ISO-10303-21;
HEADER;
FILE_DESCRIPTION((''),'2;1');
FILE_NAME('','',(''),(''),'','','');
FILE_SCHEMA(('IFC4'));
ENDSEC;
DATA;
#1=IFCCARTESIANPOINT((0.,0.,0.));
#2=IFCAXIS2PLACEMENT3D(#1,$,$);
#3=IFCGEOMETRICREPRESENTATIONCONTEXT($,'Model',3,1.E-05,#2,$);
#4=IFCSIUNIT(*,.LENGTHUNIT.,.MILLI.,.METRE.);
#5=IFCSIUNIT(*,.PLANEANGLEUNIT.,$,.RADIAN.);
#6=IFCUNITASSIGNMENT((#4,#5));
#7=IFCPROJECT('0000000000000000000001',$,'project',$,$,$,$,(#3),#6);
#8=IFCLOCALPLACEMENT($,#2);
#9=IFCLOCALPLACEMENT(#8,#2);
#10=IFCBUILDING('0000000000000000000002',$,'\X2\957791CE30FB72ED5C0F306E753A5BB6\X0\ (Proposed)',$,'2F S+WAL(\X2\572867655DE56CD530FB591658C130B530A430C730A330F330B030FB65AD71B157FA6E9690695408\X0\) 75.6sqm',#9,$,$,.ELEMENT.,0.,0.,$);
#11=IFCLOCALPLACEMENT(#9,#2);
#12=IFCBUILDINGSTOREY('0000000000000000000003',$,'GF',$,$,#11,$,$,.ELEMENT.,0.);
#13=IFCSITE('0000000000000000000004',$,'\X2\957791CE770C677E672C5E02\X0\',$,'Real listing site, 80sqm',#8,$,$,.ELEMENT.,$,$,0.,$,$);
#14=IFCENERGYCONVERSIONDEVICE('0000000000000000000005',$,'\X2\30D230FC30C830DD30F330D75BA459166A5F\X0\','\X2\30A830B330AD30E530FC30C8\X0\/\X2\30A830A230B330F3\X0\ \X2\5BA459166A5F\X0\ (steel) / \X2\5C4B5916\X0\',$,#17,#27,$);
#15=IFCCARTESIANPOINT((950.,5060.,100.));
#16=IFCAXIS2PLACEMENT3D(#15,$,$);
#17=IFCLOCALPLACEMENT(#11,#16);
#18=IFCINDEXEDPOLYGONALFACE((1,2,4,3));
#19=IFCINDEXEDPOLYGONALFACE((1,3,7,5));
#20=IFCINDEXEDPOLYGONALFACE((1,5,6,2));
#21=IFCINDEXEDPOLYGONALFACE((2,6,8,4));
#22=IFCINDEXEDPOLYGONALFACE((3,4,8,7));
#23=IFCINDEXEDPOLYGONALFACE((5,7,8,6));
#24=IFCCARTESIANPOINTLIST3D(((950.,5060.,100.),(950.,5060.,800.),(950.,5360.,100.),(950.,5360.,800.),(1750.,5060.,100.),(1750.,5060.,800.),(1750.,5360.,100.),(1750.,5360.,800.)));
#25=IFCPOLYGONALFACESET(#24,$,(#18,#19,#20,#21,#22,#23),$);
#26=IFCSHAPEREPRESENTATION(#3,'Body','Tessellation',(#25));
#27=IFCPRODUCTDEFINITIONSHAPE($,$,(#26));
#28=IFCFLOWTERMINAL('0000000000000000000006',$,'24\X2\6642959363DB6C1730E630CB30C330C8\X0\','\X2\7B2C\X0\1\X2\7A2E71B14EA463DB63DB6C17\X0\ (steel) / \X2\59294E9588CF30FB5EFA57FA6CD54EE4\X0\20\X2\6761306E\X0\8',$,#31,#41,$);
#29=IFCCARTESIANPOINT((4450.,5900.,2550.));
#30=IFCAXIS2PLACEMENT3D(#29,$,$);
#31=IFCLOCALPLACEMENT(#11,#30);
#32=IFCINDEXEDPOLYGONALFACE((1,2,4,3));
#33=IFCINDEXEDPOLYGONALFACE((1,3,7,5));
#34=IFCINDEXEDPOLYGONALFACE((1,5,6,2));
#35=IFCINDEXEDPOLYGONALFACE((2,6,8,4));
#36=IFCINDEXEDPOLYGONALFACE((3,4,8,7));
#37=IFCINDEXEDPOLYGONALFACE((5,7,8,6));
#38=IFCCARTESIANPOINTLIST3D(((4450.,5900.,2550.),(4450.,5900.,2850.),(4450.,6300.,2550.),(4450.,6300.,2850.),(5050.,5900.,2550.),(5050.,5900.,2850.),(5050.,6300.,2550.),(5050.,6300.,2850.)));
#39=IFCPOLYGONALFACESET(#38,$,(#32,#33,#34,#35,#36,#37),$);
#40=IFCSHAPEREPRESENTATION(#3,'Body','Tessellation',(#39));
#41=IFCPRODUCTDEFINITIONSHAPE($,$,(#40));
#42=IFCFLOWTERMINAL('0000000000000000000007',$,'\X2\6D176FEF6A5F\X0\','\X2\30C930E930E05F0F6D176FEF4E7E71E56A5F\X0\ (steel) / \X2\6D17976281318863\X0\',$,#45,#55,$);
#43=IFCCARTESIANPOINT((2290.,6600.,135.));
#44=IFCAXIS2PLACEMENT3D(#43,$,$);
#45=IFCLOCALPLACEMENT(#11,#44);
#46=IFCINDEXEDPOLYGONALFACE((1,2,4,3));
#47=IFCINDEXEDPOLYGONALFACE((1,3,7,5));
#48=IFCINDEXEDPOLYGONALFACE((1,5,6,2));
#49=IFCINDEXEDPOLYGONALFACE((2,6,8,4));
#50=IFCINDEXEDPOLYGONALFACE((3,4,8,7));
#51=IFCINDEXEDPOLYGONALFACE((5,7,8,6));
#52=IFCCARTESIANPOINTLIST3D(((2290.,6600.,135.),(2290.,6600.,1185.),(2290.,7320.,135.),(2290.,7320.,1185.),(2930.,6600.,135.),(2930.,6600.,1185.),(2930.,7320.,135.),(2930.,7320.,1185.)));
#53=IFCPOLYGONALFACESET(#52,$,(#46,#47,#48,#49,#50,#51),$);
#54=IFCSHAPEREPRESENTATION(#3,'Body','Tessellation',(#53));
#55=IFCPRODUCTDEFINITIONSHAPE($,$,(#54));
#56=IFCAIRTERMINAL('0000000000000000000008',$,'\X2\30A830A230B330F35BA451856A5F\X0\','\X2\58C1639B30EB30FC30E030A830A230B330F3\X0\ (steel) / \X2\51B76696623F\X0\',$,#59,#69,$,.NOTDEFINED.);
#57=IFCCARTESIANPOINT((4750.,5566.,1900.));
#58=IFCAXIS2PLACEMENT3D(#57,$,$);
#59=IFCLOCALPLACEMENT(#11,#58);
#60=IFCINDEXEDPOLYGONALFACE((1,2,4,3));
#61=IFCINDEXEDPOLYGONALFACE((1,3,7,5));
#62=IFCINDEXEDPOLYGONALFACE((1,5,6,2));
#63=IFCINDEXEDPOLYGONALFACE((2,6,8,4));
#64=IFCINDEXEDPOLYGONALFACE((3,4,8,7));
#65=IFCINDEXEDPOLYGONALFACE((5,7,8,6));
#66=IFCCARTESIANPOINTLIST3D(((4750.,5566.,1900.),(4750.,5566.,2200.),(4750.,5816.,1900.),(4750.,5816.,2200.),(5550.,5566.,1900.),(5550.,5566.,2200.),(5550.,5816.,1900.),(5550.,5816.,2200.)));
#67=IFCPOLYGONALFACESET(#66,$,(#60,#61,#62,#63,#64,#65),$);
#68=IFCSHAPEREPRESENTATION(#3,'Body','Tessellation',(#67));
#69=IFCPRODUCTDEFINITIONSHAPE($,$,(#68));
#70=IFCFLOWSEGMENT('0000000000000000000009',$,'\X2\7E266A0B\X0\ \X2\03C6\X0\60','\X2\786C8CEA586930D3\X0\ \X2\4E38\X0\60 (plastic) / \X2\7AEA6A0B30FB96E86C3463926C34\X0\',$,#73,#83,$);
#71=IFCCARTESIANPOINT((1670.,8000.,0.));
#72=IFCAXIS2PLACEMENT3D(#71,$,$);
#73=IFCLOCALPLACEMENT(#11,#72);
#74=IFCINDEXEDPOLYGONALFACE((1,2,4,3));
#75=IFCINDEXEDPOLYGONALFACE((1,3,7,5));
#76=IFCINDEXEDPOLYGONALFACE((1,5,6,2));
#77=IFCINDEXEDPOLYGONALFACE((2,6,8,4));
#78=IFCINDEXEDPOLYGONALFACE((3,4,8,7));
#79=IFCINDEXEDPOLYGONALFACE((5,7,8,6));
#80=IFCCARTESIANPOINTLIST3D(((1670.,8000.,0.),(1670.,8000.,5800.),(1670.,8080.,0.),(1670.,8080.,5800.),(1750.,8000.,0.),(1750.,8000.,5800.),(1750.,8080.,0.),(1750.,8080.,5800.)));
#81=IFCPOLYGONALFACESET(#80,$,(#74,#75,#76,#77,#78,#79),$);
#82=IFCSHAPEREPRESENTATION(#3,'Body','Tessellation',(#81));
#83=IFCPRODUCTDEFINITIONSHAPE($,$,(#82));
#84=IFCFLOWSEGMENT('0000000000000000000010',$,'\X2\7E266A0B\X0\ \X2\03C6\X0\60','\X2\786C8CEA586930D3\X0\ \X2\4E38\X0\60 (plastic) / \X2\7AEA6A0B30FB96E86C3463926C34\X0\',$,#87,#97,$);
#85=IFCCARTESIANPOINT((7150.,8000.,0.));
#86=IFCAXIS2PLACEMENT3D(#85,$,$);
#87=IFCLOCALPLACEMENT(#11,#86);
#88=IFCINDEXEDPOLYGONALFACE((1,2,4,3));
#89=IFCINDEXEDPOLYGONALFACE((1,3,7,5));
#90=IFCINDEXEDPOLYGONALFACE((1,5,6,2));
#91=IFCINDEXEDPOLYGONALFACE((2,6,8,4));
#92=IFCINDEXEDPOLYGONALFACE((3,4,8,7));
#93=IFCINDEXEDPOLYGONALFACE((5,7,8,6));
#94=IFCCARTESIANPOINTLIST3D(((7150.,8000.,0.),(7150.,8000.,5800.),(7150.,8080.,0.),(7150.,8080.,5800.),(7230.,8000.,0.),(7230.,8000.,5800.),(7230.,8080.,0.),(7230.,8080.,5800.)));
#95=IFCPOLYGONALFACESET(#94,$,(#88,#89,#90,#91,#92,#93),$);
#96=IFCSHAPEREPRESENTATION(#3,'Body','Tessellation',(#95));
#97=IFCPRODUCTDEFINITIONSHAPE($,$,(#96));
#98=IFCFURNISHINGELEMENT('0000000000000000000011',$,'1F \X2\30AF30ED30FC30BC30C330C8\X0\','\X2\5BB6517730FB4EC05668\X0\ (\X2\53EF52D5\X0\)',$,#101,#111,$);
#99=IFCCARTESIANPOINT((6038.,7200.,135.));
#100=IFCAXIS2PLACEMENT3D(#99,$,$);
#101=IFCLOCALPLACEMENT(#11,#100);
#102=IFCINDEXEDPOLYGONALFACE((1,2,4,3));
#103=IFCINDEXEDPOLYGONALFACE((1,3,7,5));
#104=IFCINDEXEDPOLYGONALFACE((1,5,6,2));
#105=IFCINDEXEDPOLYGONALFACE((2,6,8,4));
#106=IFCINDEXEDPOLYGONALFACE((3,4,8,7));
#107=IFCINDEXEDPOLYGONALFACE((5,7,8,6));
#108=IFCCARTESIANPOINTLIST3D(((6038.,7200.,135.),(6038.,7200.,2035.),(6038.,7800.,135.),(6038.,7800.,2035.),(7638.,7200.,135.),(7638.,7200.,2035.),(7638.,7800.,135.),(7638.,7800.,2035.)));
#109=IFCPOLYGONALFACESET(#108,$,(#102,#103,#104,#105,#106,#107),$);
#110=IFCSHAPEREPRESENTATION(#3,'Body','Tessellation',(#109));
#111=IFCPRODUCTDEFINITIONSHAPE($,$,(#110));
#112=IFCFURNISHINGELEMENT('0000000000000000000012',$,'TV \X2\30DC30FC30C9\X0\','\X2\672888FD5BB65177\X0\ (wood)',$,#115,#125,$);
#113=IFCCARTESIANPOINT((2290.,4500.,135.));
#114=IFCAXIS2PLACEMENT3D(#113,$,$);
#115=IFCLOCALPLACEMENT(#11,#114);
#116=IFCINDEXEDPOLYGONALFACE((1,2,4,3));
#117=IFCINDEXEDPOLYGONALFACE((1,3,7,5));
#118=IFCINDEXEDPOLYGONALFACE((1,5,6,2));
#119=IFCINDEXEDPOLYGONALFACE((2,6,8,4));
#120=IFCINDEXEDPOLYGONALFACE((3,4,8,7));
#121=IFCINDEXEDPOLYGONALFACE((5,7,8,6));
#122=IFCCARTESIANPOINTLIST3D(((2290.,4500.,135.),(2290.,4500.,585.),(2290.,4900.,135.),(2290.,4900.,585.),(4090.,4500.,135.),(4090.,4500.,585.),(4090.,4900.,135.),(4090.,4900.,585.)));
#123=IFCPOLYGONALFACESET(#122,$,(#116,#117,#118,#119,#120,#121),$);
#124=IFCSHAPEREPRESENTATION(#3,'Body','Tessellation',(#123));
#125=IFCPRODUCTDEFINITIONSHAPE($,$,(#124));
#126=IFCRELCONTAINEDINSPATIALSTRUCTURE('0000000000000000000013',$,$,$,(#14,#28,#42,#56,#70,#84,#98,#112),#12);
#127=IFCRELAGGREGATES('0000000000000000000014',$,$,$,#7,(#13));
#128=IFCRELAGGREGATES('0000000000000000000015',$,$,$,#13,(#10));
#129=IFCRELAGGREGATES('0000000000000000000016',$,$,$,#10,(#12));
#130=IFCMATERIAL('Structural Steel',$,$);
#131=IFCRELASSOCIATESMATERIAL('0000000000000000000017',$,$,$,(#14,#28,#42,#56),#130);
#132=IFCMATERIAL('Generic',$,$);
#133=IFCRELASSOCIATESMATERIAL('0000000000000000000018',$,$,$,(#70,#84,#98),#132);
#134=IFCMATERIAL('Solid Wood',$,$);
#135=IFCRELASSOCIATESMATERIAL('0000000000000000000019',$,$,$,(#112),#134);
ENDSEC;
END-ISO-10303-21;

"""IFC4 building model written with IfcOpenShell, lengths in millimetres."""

from ifc_helpers import new_model, si_unit, frame, frame_2d, origin, place, context, project, spatial, rectangle, extrude, material, element, save


model = new_model("IFC4")

# Units and contexts
model_context = context("Model", 3, precision=1e-05, world=origin())
ifc_project = project(units=[si_unit("LENGTHUNIT", "METRE", prefix="MILLI"), si_unit("PLANEANGLEUNIT", "RADIAN")], contexts=[model_context])

# Site, building, storey
site_placement = place(None, origin())
site = spatial("IfcSite", under=ifc_project, at=site_placement, Name="長野県松本市", ObjectType="Real listing site, 80sqm", CompositionType="ELEMENT", RefElevation=0.0)
building_placement = place(site_placement, origin())
building = spatial("IfcBuilding", under=site, at=building_placement, Name="長野・狭小の町家 (Proposed)", ObjectType="2F S+WAL(在来工法・外壁サイディング・断熱基準適合) 75.6sqm", CompositionType="ELEMENT", ElevationOfRefHeight=0.0, ElevationOfTerrain=0.0)
storey_placement = place(building_placement, origin())
storey = spatial("IfcBuildingStorey", under=building, at=storey_placement, Name="GF", CompositionType="ELEMENT", Elevation=0.0)

# Shared definitions
ifc_material_1 = material(Name="Solid Wood")

# Shared definitions
ifc_material_2 = material(Name="Generic")

# Shared definitions
ifc_material_3 = material(Name="Structural Steel")

# Energy conversion device
energy_conversion_device_placement = place(storey_placement, frame((950.0, 5060.0, 100.0)))
element("IfcEnergyConversionDevice", 1, at=energy_conversion_device_placement, inside=storey, material=ifc_material_3, Name="ヒートポンプ室外機", Description="エコキュート/エアコン 室外機 (steel) / 屋外", context=model_context, shape_type="SweptSolid", body=[
    extrude(rectangle(XDim=800.0, YDim=300.0, at=frame_2d((400.0, 150.0))), frame((950.0, 5060.0, 100.0)), (0.0, 0.0, 1.0), 700.0),
])

# Flow terminals
flow_terminal_1_placement = place(storey_placement, frame((4450.0, 5900.0, 2550.0)))
element("IfcFlowTerminal", 2, at=flow_terminal_1_placement, inside=storey, material=ifc_material_3, Name="24時間換気ユニット", Description="第1種熱交換換気 (steel) / 天井裏・建基法令20条の8", context=model_context, shape_type="SweptSolid", body=[
    extrude(rectangle(XDim=600.0, YDim=400.0, at=frame_2d((300.0, 200.0))), frame((4450.0, 5900.0, 2550.0)), (0.0, 0.0, 1.0), 300.0),
])
flow_terminal_2_placement = place(storey_placement, frame((2290.0, 6600.0, 135.0)))
element("IfcFlowTerminal", 3, at=flow_terminal_2_placement, inside=storey, material=ifc_material_3, Name="洗濯機", Description="ドラム式洗濯乾燥機 (steel) / 洗面脱衣", context=model_context, shape_type="SweptSolid", body=[
    extrude(rectangle(XDim=640.0, YDim=720.0, at=frame_2d((320.0, 360.0))), frame((2290.0, 6600.0, 135.0)), (0.0, 0.0, 1.0), 1050.0),
])

# Air terminal
air_terminal_placement = place(storey_placement, frame((4750.0, 5566.0, 1900.0)))
element("IfcAirTerminal", 4, at=air_terminal_placement, inside=storey, material=ifc_material_3, Name="エアコン室内機", Description="壁掛ルームエアコン (steel) / 冷暖房", PredefinedType="NOTDEFINED", context=model_context, shape_type="SweptSolid", body=[
    extrude(rectangle(XDim=800.0, YDim=250.0, at=frame_2d((400.0, 125.0))), frame((4750.0, 5566.0, 1900.0)), (0.0, 0.0, 1.0), 300.0),
])

# Flow segments
flow_segment_1_placement = place(storey_placement, frame((1670.0, 8000.0, 0.0)))
element("IfcFlowSegment", 5, at=flow_segment_1_placement, inside=storey, material=ifc_material_2, Name="縦樋 φ60", Description="硬質塩ビ 丸60 (plastic) / 竪樋・雨水排水", context=model_context, shape_type="SweptSolid", body=[
    extrude(rectangle(XDim=80.0, YDim=80.0, at=frame_2d((40.0, 40.0))), frame((1670.0, 8000.0, 0.0)), (0.0, 0.0, 1.0), 5800.0),
])
flow_segment_2_placement = place(storey_placement, frame((7150.0, 8000.0, 0.0)))
element("IfcFlowSegment", 6, at=flow_segment_2_placement, inside=storey, material=ifc_material_2, Name="縦樋 φ60", Description="硬質塩ビ 丸60 (plastic) / 竪樋・雨水排水", context=model_context, shape_type="SweptSolid", body=[
    extrude(rectangle(XDim=80.0, YDim=80.0, at=frame_2d((40.0, 40.0))), frame((7150.0, 8000.0, 0.0)), (0.0, 0.0, 1.0), 5800.0),
])

# Furnishing elements
furnishing_1_placement = place(storey_placement, frame((6038.0, 7200.0, 135.0)))
element("IfcFurnishingElement", 7, at=furnishing_1_placement, inside=storey, material=ifc_material_2, Name="1F クローゼット", Description="家具・什器 (可動)", context=model_context, shape_type="SweptSolid", body=[
    extrude(rectangle(XDim=1600.0, YDim=600.0, at=frame_2d((800.0, 300.0))), frame((6038.0, 7200.0, 135.0)), (0.0, 0.0, 1.0), 1900.0),
])
furnishing_2_placement = place(storey_placement, frame((2290.0, 4500.0, 135.0)))
element("IfcFurnishingElement", 8, at=furnishing_2_placement, inside=storey, material=ifc_material_1, Name="TV ボード", Description="木製家具 (wood)", context=model_context, shape_type="SweptSolid", body=[
    extrude(rectangle(XDim=1800.0, YDim=400.0, at=frame_2d((900.0, 200.0))), frame((2290.0, 4500.0, 135.0)), (0.0, 0.0, 1.0), 450.0),
])

save(model, "model.ifc")
